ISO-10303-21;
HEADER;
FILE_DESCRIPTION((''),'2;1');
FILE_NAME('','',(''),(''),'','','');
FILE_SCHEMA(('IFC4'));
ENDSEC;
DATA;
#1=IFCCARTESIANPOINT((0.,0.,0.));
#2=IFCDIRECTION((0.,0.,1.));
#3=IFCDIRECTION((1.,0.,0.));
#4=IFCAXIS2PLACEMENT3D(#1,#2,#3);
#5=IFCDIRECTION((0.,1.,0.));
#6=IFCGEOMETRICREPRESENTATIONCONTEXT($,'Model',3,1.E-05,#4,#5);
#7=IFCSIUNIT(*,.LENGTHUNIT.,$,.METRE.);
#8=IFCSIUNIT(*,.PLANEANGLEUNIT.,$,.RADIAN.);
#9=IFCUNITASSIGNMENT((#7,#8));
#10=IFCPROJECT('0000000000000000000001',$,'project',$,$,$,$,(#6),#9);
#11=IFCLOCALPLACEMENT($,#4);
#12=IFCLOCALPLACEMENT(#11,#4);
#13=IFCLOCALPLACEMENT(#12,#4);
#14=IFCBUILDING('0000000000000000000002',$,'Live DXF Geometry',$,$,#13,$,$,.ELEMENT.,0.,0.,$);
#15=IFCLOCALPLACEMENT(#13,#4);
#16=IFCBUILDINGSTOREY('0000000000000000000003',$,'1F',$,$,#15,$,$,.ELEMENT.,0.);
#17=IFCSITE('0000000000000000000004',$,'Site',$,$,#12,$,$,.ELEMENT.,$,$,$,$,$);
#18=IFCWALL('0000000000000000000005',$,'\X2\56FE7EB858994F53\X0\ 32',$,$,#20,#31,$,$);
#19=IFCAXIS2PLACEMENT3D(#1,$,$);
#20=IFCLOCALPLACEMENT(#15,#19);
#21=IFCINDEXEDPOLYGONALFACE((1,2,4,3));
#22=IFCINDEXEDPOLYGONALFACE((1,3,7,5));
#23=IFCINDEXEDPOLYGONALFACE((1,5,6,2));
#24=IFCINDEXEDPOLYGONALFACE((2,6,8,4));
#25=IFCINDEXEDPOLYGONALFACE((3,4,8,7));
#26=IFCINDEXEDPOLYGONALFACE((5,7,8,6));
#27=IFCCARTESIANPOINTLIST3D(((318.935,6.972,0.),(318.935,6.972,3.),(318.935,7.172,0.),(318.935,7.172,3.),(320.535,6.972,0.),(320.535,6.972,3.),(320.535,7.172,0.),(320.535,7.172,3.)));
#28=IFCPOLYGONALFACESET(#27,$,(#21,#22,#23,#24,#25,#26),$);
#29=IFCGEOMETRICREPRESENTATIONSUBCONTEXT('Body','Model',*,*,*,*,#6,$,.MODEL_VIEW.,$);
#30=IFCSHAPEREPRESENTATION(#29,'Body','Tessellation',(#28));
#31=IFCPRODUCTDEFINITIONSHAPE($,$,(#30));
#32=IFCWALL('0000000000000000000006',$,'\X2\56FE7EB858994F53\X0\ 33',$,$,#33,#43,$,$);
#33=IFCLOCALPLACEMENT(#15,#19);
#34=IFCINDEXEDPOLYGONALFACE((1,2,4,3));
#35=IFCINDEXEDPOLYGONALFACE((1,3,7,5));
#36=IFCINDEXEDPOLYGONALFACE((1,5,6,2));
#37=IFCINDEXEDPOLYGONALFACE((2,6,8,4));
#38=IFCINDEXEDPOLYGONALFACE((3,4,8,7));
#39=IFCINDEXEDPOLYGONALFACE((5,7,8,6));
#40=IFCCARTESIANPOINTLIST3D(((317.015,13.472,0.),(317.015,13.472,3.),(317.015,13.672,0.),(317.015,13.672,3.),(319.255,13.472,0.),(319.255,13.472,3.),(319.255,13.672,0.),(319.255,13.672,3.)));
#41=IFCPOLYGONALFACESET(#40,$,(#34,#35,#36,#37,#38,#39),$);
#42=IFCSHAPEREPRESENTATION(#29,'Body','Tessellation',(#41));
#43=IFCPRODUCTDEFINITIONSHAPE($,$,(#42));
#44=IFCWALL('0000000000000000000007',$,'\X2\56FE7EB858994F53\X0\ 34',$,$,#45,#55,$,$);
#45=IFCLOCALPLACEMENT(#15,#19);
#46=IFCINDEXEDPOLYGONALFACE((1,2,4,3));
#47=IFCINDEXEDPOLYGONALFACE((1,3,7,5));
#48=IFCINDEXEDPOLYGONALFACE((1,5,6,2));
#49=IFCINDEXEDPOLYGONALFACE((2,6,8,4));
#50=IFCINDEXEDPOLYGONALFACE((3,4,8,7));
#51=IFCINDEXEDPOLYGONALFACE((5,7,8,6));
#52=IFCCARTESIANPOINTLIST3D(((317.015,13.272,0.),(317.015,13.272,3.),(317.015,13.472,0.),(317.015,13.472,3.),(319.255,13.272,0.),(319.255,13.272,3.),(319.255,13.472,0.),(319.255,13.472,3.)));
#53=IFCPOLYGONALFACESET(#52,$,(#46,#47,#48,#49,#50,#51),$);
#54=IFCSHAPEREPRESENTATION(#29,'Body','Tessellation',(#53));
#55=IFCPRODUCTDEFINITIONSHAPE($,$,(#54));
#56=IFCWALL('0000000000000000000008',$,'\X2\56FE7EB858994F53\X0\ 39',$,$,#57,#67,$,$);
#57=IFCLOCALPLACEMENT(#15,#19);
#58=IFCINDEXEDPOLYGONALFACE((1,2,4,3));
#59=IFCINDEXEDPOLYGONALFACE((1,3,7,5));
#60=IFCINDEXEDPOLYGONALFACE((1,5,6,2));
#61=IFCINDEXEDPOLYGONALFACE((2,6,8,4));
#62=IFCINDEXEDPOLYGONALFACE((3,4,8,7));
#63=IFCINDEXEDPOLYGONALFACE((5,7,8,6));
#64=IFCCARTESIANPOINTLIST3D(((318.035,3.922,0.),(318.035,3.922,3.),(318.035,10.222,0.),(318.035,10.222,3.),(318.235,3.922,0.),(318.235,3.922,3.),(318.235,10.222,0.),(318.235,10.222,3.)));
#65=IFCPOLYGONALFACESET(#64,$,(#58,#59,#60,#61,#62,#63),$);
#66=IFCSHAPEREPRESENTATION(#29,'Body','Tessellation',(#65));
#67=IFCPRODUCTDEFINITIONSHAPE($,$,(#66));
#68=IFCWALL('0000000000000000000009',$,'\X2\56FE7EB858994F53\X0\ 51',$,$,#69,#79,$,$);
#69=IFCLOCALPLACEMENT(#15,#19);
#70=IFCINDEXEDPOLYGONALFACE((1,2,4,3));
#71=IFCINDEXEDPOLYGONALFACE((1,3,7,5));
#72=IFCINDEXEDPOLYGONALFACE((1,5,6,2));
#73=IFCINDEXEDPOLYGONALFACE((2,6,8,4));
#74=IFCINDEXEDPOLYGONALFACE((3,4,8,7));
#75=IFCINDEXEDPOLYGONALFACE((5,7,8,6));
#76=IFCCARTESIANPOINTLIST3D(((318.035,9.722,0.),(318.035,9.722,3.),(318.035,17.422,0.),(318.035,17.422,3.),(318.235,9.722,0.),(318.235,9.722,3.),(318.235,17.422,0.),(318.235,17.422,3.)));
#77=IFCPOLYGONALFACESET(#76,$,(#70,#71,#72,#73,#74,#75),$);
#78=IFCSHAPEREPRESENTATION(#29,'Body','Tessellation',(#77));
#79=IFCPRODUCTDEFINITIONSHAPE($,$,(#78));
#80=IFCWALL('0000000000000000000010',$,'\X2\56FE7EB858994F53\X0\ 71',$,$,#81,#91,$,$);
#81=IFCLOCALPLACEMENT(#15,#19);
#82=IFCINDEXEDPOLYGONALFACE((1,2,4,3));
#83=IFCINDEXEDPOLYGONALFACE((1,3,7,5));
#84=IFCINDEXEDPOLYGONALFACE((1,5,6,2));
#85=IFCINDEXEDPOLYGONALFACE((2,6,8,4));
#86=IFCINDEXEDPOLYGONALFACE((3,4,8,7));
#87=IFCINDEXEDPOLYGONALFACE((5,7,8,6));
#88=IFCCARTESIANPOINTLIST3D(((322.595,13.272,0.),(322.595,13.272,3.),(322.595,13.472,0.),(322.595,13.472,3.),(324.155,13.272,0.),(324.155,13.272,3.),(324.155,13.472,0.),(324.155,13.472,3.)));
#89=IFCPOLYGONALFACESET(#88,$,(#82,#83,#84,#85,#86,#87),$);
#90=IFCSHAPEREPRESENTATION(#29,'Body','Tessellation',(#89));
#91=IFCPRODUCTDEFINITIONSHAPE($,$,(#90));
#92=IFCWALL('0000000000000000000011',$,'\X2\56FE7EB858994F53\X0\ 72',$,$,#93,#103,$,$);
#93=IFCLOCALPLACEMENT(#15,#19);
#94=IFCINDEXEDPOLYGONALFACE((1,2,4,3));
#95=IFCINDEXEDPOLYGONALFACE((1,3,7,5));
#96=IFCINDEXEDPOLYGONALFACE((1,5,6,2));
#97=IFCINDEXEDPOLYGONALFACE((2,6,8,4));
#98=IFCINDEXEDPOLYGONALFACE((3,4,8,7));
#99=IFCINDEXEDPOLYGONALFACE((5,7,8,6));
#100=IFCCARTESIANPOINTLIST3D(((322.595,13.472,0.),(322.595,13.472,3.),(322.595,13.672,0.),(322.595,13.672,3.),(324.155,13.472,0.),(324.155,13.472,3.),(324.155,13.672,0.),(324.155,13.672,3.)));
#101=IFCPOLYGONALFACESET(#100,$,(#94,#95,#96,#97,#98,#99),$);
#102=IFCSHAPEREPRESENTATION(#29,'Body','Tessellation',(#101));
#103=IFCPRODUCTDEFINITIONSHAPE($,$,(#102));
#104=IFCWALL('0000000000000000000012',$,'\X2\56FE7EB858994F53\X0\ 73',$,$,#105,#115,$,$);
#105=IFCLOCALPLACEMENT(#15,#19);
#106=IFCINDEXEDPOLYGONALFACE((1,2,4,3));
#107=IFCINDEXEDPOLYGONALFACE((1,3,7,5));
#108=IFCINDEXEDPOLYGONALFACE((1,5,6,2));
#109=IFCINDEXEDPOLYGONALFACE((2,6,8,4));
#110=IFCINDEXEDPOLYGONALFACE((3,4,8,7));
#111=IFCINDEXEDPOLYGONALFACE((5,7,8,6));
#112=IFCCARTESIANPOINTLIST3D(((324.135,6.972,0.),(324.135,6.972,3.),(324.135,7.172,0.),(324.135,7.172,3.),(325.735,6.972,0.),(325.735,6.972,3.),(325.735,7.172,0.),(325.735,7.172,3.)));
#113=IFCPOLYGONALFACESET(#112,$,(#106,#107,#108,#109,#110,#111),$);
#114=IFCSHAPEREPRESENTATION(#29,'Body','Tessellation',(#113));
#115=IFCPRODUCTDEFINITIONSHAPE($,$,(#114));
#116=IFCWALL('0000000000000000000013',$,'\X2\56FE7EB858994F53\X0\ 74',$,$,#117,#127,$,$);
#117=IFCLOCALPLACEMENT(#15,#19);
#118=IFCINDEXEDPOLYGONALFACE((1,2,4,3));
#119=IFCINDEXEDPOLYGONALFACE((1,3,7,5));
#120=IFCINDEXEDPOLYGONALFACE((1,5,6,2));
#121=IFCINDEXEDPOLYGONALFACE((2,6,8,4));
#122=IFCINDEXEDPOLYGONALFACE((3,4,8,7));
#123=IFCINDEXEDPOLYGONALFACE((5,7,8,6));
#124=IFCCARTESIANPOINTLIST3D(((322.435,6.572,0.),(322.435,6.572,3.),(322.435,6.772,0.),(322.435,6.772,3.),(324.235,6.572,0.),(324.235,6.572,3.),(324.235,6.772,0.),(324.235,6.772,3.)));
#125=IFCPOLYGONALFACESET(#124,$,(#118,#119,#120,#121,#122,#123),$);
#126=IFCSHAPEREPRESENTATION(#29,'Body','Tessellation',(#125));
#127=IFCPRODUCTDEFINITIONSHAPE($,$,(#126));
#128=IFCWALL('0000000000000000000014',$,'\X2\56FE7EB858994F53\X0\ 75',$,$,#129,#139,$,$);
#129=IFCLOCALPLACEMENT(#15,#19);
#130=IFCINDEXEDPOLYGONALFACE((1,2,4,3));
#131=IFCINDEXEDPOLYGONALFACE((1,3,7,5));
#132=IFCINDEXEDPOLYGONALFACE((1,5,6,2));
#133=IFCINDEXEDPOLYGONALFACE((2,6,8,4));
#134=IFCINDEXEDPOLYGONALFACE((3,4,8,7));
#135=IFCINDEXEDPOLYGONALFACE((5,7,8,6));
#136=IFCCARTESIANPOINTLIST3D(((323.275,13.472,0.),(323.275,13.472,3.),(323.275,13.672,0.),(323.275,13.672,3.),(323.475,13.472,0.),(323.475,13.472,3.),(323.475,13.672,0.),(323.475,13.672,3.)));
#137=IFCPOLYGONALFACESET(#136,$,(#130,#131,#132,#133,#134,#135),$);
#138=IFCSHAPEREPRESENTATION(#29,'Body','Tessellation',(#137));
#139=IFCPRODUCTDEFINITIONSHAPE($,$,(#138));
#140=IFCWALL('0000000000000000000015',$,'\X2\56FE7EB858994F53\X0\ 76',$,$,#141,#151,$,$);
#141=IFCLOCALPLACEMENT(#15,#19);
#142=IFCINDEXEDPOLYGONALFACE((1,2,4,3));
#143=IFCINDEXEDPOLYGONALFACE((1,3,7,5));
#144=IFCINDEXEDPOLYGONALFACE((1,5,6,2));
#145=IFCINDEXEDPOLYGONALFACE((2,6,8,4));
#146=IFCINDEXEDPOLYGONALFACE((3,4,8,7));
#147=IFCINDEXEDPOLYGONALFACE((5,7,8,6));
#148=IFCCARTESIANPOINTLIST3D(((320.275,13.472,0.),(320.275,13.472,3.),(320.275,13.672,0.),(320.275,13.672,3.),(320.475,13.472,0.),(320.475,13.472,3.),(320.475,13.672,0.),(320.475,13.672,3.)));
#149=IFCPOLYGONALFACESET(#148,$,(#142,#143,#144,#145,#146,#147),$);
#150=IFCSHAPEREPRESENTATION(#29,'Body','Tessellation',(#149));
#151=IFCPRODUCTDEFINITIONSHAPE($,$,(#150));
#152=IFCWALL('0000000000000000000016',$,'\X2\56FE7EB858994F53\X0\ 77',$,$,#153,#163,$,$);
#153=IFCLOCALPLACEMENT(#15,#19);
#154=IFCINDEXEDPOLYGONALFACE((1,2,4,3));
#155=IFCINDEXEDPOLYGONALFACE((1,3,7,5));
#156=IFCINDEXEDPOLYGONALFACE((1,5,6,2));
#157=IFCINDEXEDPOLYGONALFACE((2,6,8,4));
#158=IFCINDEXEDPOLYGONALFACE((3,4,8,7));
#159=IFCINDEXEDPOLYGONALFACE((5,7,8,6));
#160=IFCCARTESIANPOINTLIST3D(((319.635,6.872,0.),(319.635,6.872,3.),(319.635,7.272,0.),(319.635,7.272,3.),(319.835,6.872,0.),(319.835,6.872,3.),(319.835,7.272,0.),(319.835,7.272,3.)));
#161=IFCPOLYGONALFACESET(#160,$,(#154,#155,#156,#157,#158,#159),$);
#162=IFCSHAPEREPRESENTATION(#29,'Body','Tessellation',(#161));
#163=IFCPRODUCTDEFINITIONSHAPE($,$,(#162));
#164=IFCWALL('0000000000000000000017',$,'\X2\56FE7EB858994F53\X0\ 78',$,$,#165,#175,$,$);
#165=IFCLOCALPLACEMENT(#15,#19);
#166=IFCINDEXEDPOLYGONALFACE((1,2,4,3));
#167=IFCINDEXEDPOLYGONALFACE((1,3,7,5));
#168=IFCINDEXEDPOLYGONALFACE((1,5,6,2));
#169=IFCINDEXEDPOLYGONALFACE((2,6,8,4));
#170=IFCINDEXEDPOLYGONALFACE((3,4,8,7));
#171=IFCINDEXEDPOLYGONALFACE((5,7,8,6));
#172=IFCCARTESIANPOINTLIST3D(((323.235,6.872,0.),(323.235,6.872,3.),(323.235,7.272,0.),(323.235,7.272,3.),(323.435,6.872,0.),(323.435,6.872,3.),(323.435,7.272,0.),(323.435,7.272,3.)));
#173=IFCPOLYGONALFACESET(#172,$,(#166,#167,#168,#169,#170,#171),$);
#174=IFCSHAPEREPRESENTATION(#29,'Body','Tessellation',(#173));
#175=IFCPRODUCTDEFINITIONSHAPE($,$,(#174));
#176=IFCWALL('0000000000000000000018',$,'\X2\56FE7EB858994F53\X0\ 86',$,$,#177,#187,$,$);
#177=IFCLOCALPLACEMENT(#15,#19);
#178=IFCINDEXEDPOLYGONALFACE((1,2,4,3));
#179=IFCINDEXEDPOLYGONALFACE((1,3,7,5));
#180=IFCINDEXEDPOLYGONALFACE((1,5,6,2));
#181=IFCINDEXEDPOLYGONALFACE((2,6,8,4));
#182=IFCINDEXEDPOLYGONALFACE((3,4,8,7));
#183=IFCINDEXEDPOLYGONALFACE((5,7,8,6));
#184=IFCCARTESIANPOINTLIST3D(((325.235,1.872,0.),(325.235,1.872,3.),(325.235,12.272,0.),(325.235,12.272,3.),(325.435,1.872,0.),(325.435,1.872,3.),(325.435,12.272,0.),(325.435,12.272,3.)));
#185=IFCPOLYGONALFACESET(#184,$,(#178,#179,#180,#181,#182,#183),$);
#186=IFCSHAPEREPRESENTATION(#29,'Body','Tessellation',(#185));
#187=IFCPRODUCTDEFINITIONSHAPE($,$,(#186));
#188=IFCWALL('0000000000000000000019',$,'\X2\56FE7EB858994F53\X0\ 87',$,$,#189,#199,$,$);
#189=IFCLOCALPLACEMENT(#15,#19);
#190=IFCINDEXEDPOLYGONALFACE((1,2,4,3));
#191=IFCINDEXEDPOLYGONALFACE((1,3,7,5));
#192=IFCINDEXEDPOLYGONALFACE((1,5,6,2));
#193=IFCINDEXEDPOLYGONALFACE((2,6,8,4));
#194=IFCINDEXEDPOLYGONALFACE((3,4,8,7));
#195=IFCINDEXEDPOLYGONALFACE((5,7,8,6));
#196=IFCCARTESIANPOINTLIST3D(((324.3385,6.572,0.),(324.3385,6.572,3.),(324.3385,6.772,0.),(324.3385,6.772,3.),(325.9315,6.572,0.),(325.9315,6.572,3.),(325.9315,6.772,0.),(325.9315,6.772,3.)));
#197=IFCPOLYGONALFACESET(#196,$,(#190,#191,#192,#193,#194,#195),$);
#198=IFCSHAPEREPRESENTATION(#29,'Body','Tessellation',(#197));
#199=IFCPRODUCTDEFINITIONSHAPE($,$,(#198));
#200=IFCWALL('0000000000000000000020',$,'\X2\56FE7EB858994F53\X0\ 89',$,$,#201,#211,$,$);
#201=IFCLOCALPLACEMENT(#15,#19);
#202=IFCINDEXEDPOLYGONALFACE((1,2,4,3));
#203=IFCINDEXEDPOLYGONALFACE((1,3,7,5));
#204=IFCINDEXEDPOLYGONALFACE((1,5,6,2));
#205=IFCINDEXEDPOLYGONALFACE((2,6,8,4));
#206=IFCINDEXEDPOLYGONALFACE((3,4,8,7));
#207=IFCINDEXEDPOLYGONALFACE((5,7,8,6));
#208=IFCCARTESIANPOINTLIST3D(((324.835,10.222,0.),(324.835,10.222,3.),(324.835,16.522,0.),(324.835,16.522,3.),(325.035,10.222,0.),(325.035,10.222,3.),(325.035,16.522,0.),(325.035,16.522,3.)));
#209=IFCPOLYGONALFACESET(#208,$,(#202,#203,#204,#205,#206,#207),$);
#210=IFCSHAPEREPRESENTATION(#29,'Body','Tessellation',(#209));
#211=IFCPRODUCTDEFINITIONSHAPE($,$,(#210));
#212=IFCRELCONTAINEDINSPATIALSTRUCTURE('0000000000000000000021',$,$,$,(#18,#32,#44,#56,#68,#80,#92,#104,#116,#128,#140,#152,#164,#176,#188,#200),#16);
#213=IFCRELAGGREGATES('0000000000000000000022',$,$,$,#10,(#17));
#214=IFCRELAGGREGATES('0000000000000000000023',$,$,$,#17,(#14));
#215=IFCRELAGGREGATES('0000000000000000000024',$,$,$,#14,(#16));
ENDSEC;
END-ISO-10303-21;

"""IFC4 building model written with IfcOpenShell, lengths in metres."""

from ifc_helpers import new_model, si_unit, direction, frame, frame_2d, origin_with_axes, place, context, subcontext, project, spatial, rectangle, extrude, element, save


model = new_model("IFC4")

# Units and contexts
model_context = context("Model", 3, precision=1e-05, world=origin_with_axes(), true_north=direction((0.0, 1.0, 0.0)))
body_context = subcontext(model_context, "Body", "Model", "MODEL_VIEW")
ifc_project = project(units=[si_unit("LENGTHUNIT", "METRE"), si_unit("PLANEANGLEUNIT", "RADIAN")], contexts=[model_context])

# Site, building, storey
placement = place(None, origin_with_axes())
site_placement = place(placement, origin_with_axes())
site = spatial("IfcSite", under=ifc_project, at=site_placement, Name="Site", CompositionType="ELEMENT")
building_placement = place(site_placement, origin_with_axes())
building = spatial("IfcBuilding", under=site, at=building_placement, Name="Live DXF Geometry", CompositionType="ELEMENT", ElevationOfRefHeight=0.0, ElevationOfTerrain=0.0)
storey_placement = place(building_placement, origin_with_axes())
storey = spatial("IfcBuildingStorey", under=building, at=storey_placement, Name="1F", CompositionType="ELEMENT", Elevation=0.0)

# Walls
wall_1_placement = place(storey_placement, frame((319.735, 7.072, 0.0), z_axis=(0.0, 0.0, 1.0), x_axis=(-1.0, 0.0, 0.0)))
element("IfcWall", 1, at=wall_1_placement, inside=storey, Name="图纸墙体 32", context=body_context, shape_type="SweptSolid", body=[
    extrude(rectangle(XDim=1.6, YDim=0.2, at=frame_2d((0.0, 0.0), x_axis=(1.0, 0.0, 0.0))), frame((0.0, 0.0, 0.0), z_axis=(0.0, 0.0, 1.0)), (0.0, 0.0, 1.0), 3.0),
])
for number, where, z_axis, x_axis, name in (
    (2, (318.135, 13.572, 0.0), (0.0, 0.0, 1.0), (1.0, 0.0, 0.0), "图纸墙体 33"),
    (3, (318.135, 13.372, 0.0), (0.0, 0.0, 1.0), (1.0, 0.0, 0.0), "图纸墙体 34"),
):
    element("IfcWall", number, at=place(storey_placement, frame(where, z_axis=z_axis, x_axis=x_axis)), inside=storey, Name=name, context=body_context, shape_type="SweptSolid", body=[
        extrude(rectangle(XDim=2.24, YDim=0.2, at=frame_2d((0.0, 0.0), x_axis=(1.0, 0.0, 0.0))), frame((0.0, 0.0, 0.0), z_axis=(0.0, 0.0, 1.0)), (0.0, 0.0, 1.0), 3.0),
    ])
wall_2_placement = place(storey_placement, frame((318.135, 7.072, 0.0), z_axis=(0.0, 0.0, 1.0), x_axis=(0.0, 1.0, 0.0)))
element("IfcWall", 4, at=wall_2_placement, inside=storey, Name="图纸墙体 39", context=body_context, shape_type="SweptSolid", body=[
    extrude(rectangle(XDim=6.3, YDim=0.2, at=frame_2d((0.0, 0.0), x_axis=(1.0, 0.0, 0.0))), frame((0.0, 0.0, 0.0), z_axis=(0.0, 0.0, 1.0)), (0.0, 0.0, 1.0), 3.0),
])
wall_3_placement = place(storey_placement, frame((318.135, 13.572, 0.0), z_axis=(0.0, 0.0, 1.0), x_axis=(0.0, 1.0, 0.0)))
element("IfcWall", 5, at=wall_3_placement, inside=storey, Name="图纸墙体 51", context=body_context, shape_type="SweptSolid", body=[
    extrude(rectangle(XDim=7.7, YDim=0.2, at=frame_2d((0.0, 0.0), x_axis=(1.0, 0.0, 0.0))), frame((0.0, 0.0, 0.0), z_axis=(0.0, 0.0, 1.0)), (0.0, 0.0, 1.0), 3.0),
])
for number, where, z_axis, x_axis, name in (
    (6, (323.375, 13.372, 0.0), (0.0, 0.0, 1.0), (1.0, 0.0, 0.0), "图纸墙体 71"),
    (7, (323.375, 13.572, 0.0), (0.0, 0.0, 1.0), (1.0, 0.0, 0.0), "图纸墙体 72"),
):
    element("IfcWall", number, at=place(storey_placement, frame(where, z_axis=z_axis, x_axis=x_axis)), inside=storey, Name=name, context=body_context, shape_type="SweptSolid", body=[
        extrude(rectangle(XDim=1.56, YDim=0.2, at=frame_2d((0.0, 0.0), x_axis=(1.0, 0.0, 0.0))), frame((0.0, 0.0, 0.0), z_axis=(0.0, 0.0, 1.0)), (0.0, 0.0, 1.0), 3.0),
    ])
wall_4_placement = place(storey_placement, frame((324.935, 7.072, 0.0), z_axis=(0.0, 0.0, 1.0), x_axis=(-1.0, 0.0, 0.0)))
element("IfcWall", 8, at=wall_4_placement, inside=storey, Name="图纸墙体 73", context=body_context, shape_type="SweptSolid", body=[
    extrude(rectangle(XDim=1.6, YDim=0.2, at=frame_2d((0.0, 0.0), x_axis=(1.0, 0.0, 0.0))), frame((0.0, 0.0, 0.0), z_axis=(0.0, 0.0, 1.0)), (0.0, 0.0, 1.0), 3.0),
])
wall_5_placement = place(storey_placement, frame((323.335, 6.672, 0.0), z_axis=(0.0, 0.0, 1.0), x_axis=(1.0, 0.0, 0.0)))
element("IfcWall", 9, at=wall_5_placement, inside=storey, Name="图纸墙体 74", context=body_context, shape_type="SweptSolid", body=[
    extrude(rectangle(XDim=1.8, YDim=0.2, at=frame_2d((0.0, 0.0), x_axis=(1.0, 0.0, 0.0))), frame((0.0, 0.0, 0.0), z_axis=(0.0, 0.0, 1.0)), (0.0, 0.0, 1.0), 3.0),
])
for number, where, z_axis, x_axis, name in (
    (10, (323.375, 13.572, 0.0), (0.0, 0.0, 1.0), (0.0, -1.0, 0.0), "图纸墙体 75"),
    (11, (320.375, 13.572, 0.0), (0.0, 0.0, 1.0), (0.0, -1.0, 0.0), "图纸墙体 76"),
):
    element("IfcWall", number, at=place(storey_placement, frame(where, z_axis=z_axis, x_axis=x_axis)), inside=storey, Name=name, context=body_context, shape_type="SweptSolid", body=[
        extrude(rectangle(XDim=0.2, YDim=0.2, at=frame_2d((0.0, 0.0), x_axis=(1.0, 0.0, 0.0))), frame((0.0, 0.0, 0.0), z_axis=(0.0, 0.0, 1.0)), (0.0, 0.0, 1.0), 3.0),
    ])
for number, where, z_axis, x_axis, name in (
    (12, (319.735, 7.072, 0.0), (0.0, 0.0, 1.0), (0.0, -1.0, 0.0), "图纸墙体 77"),
    (13, (323.335, 7.072, 0.0), (0.0, 0.0, 1.0), (0.0, -1.0, 0.0), "图纸墙体 78"),
):
    element("IfcWall", number, at=place(storey_placement, frame(where, z_axis=z_axis, x_axis=x_axis)), inside=storey, Name=name, context=body_context, shape_type="SweptSolid", body=[
        extrude(rectangle(XDim=0.4, YDim=0.2, at=frame_2d((0.0, 0.0), x_axis=(1.0, 0.0, 0.0))), frame((0.0, 0.0, 0.0), z_axis=(0.0, 0.0, 1.0)), (0.0, 0.0, 1.0), 3.0),
    ])
wall_6_placement = place(storey_placement, frame((325.335, 7.072, 0.0), z_axis=(0.0, 0.0, 1.0), x_axis=(0.0, 1.0, 0.0)))
element("IfcWall", 14, at=wall_6_placement, inside=storey, Name="图纸墙体 86", context=body_context, shape_type="SweptSolid", body=[
    extrude(rectangle(XDim=10.4, YDim=0.2, at=frame_2d((0.0, 0.0), x_axis=(1.0, 0.0, 0.0))), frame((0.0, 0.0, 0.0), z_axis=(0.0, 0.0, 1.0)), (0.0, 0.0, 1.0), 3.0),
])
wall_7_placement = place(storey_placement, frame((325.135, 6.672, 0.0), z_axis=(0.0, 0.0, 1.0), x_axis=(1.0, 0.0, 0.0)))
element("IfcWall", 15, at=wall_7_placement, inside=storey, Name="图纸墙体 87", context=body_context, shape_type="SweptSolid", body=[
    extrude(rectangle(XDim=1.593, YDim=0.2, at=frame_2d((0.0, 0.0), x_axis=(1.0, 0.0, 0.0))), frame((0.0, 0.0, 0.0), z_axis=(0.0, 0.0, 1.0)), (0.0, 0.0, 1.0), 3.0),
])
wall_8_placement = place(storey_placement, frame((324.935, 13.372, 0.0), z_axis=(0.0, 0.0, 1.0), x_axis=(0.0, -1.0, 0.0)))
element("IfcWall", 16, at=wall_8_placement, inside=storey, Name="图纸墙体 89", context=body_context, shape_type="SweptSolid", body=[
    extrude(rectangle(XDim=6.3, YDim=0.2, at=frame_2d((0.0, 0.0), x_axis=(1.0, 0.0, 0.0))), frame((0.0, 0.0, 0.0), z_axis=(0.0, 0.0, 1.0)), (0.0, 0.0, 1.0), 3.0),
])

save(model, "model.ifc")
